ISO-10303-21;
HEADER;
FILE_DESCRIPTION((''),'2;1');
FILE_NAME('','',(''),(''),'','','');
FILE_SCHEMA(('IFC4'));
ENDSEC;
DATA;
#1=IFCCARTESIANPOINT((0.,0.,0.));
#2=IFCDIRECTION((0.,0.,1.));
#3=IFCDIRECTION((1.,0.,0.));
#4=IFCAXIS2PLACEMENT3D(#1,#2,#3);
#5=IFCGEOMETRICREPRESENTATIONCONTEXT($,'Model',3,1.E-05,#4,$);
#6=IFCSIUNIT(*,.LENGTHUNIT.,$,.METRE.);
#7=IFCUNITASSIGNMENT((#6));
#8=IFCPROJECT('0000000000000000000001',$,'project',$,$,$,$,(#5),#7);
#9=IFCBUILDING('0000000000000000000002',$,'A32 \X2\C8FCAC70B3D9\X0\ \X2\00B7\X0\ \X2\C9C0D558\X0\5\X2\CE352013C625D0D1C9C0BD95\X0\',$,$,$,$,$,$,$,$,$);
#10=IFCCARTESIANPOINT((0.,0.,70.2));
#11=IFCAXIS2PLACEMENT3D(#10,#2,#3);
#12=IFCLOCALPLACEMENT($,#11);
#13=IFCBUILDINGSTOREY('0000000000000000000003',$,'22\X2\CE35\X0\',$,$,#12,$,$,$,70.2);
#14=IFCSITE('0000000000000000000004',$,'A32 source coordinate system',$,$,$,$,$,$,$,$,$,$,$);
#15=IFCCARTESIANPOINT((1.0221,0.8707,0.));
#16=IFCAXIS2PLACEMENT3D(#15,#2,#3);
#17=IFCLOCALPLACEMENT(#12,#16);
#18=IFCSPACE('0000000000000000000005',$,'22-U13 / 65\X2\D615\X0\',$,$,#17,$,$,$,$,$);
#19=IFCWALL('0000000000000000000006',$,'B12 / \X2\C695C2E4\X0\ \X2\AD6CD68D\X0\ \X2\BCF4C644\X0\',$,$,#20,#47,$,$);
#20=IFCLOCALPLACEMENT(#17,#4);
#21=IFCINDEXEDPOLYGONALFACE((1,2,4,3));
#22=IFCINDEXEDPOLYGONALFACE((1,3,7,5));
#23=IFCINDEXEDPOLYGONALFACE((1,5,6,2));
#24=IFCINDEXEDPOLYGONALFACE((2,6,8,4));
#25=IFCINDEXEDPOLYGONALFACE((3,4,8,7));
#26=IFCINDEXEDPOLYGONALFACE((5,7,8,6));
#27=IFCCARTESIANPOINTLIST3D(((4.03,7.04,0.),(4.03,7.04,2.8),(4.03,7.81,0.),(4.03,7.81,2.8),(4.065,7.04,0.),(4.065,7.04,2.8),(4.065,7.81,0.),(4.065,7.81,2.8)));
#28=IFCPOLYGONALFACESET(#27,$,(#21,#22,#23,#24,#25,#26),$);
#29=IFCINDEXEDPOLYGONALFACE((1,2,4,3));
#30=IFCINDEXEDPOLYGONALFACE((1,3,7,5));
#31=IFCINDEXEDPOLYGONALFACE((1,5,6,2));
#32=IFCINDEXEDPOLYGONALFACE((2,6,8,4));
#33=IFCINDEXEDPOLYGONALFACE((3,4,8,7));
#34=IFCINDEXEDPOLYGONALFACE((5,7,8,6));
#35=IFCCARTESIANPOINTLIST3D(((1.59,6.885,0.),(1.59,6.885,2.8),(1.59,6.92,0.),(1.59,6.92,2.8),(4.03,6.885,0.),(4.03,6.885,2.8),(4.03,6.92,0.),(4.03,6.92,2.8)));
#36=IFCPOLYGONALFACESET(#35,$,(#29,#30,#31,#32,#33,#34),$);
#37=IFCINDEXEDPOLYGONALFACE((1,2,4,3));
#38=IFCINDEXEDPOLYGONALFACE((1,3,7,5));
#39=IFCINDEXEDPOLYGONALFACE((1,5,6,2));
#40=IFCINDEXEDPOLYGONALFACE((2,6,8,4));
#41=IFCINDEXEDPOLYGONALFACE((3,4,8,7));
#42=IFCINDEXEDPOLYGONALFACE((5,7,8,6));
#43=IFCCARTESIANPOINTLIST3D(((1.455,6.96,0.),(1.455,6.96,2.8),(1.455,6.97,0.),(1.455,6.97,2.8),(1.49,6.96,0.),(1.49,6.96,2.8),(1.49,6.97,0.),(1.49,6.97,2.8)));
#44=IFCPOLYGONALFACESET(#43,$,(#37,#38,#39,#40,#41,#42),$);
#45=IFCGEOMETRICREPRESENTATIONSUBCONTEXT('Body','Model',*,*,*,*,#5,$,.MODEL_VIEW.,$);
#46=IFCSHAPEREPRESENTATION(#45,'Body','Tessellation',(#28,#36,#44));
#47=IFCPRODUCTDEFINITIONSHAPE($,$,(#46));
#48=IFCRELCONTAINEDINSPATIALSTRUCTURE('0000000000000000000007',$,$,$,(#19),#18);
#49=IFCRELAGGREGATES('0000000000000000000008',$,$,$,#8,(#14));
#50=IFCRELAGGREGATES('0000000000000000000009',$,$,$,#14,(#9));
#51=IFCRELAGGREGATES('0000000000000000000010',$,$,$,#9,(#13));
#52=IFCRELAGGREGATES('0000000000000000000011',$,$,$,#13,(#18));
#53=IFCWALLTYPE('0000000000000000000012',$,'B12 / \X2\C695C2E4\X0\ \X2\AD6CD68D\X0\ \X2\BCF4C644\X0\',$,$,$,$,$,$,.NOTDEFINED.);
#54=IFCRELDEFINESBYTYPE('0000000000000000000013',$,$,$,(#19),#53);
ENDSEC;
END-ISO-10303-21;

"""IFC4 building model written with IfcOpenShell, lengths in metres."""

from ifc_helpers import new_model, si_unit, frame, origin, origin_with_axes, place, context, subcontext, project, spatial, polyline, outline, extrude, source, transform, mapped, type_object, type_shapes, element, save


model = new_model("IFC4")

# Units and contexts
model_context = context("Model", 3, precision=1e-05, world=origin_with_axes())
body_context = subcontext(model_context, "Body", "Model", "MODEL_VIEW")
ifc_project = project(units=[si_unit("LENGTHUNIT", "METRE")], contexts=[model_context])

# Site, building, storey, space
storey_placement = place(None, frame((0.0, 0.0, 70.2), z_axis=(0.0, 0.0, 1.0), x_axis=(1.0, 0.0, 0.0)))
space_placement = place(storey_placement, frame((1.0221, 0.8707, 0.0), z_axis=(0.0, 0.0, 1.0), x_axis=(1.0, 0.0, 0.0)))
site = spatial("IfcSite", under=ifc_project, Name="A32 source coordinate system")
building = spatial("IfcBuilding", under=site, Name="A32 주거동 · 지하5층–옥탑지붕")
storey = spatial("IfcBuildingStorey", under=building, at=storey_placement, Name="22층", Elevation=70.2)
space = spatial("IfcSpace", under=storey, at=space_placement, Name="22-U13 / 65형")

# Wall
wall_type_1 = type_object("IfcWallType", Name="B12 / 욕실 구획 보완", PredefinedType="NOTDEFINED")
shared_shape_1 = source(origin(), body_context, "Body", "SweptSolid", [
    extrude(outline(polyline([(4.065, 7.04), (4.03, 7.04), (4.03, 7.81), (4.065, 7.81), (4.065, 7.04)])), origin(), (0.0, 0.0, 1.0), 2.8),
    extrude(outline(polyline([(1.59, 6.92), (4.03, 6.92), (4.03, 6.885), (1.59, 6.885), (1.59, 6.92)])), origin(), (0.0, 0.0, 1.0), 2.8),
    extrude(outline(polyline([(1.455, 6.97), (1.49, 6.97), (1.49, 6.96), (1.455, 6.96), (1.455, 6.97)])), origin(), (0.0, 0.0, 1.0), 2.8),
])
type_shapes(wall_type_1, [shared_shape_1])
wall_1_placement = place(space_placement, origin_with_axes())
element("IfcWall", 1, at=wall_1_placement, inside=space, type_object=wall_type_1, Name="B12 / 욕실 구획 보완", context=body_context, shape_type="MappedRepresentation", body=[
    mapped(shared_shape_1, transform((0.0, 0.0, 0.0), scale=1.0)),
])

save(model, "model.ifc")
